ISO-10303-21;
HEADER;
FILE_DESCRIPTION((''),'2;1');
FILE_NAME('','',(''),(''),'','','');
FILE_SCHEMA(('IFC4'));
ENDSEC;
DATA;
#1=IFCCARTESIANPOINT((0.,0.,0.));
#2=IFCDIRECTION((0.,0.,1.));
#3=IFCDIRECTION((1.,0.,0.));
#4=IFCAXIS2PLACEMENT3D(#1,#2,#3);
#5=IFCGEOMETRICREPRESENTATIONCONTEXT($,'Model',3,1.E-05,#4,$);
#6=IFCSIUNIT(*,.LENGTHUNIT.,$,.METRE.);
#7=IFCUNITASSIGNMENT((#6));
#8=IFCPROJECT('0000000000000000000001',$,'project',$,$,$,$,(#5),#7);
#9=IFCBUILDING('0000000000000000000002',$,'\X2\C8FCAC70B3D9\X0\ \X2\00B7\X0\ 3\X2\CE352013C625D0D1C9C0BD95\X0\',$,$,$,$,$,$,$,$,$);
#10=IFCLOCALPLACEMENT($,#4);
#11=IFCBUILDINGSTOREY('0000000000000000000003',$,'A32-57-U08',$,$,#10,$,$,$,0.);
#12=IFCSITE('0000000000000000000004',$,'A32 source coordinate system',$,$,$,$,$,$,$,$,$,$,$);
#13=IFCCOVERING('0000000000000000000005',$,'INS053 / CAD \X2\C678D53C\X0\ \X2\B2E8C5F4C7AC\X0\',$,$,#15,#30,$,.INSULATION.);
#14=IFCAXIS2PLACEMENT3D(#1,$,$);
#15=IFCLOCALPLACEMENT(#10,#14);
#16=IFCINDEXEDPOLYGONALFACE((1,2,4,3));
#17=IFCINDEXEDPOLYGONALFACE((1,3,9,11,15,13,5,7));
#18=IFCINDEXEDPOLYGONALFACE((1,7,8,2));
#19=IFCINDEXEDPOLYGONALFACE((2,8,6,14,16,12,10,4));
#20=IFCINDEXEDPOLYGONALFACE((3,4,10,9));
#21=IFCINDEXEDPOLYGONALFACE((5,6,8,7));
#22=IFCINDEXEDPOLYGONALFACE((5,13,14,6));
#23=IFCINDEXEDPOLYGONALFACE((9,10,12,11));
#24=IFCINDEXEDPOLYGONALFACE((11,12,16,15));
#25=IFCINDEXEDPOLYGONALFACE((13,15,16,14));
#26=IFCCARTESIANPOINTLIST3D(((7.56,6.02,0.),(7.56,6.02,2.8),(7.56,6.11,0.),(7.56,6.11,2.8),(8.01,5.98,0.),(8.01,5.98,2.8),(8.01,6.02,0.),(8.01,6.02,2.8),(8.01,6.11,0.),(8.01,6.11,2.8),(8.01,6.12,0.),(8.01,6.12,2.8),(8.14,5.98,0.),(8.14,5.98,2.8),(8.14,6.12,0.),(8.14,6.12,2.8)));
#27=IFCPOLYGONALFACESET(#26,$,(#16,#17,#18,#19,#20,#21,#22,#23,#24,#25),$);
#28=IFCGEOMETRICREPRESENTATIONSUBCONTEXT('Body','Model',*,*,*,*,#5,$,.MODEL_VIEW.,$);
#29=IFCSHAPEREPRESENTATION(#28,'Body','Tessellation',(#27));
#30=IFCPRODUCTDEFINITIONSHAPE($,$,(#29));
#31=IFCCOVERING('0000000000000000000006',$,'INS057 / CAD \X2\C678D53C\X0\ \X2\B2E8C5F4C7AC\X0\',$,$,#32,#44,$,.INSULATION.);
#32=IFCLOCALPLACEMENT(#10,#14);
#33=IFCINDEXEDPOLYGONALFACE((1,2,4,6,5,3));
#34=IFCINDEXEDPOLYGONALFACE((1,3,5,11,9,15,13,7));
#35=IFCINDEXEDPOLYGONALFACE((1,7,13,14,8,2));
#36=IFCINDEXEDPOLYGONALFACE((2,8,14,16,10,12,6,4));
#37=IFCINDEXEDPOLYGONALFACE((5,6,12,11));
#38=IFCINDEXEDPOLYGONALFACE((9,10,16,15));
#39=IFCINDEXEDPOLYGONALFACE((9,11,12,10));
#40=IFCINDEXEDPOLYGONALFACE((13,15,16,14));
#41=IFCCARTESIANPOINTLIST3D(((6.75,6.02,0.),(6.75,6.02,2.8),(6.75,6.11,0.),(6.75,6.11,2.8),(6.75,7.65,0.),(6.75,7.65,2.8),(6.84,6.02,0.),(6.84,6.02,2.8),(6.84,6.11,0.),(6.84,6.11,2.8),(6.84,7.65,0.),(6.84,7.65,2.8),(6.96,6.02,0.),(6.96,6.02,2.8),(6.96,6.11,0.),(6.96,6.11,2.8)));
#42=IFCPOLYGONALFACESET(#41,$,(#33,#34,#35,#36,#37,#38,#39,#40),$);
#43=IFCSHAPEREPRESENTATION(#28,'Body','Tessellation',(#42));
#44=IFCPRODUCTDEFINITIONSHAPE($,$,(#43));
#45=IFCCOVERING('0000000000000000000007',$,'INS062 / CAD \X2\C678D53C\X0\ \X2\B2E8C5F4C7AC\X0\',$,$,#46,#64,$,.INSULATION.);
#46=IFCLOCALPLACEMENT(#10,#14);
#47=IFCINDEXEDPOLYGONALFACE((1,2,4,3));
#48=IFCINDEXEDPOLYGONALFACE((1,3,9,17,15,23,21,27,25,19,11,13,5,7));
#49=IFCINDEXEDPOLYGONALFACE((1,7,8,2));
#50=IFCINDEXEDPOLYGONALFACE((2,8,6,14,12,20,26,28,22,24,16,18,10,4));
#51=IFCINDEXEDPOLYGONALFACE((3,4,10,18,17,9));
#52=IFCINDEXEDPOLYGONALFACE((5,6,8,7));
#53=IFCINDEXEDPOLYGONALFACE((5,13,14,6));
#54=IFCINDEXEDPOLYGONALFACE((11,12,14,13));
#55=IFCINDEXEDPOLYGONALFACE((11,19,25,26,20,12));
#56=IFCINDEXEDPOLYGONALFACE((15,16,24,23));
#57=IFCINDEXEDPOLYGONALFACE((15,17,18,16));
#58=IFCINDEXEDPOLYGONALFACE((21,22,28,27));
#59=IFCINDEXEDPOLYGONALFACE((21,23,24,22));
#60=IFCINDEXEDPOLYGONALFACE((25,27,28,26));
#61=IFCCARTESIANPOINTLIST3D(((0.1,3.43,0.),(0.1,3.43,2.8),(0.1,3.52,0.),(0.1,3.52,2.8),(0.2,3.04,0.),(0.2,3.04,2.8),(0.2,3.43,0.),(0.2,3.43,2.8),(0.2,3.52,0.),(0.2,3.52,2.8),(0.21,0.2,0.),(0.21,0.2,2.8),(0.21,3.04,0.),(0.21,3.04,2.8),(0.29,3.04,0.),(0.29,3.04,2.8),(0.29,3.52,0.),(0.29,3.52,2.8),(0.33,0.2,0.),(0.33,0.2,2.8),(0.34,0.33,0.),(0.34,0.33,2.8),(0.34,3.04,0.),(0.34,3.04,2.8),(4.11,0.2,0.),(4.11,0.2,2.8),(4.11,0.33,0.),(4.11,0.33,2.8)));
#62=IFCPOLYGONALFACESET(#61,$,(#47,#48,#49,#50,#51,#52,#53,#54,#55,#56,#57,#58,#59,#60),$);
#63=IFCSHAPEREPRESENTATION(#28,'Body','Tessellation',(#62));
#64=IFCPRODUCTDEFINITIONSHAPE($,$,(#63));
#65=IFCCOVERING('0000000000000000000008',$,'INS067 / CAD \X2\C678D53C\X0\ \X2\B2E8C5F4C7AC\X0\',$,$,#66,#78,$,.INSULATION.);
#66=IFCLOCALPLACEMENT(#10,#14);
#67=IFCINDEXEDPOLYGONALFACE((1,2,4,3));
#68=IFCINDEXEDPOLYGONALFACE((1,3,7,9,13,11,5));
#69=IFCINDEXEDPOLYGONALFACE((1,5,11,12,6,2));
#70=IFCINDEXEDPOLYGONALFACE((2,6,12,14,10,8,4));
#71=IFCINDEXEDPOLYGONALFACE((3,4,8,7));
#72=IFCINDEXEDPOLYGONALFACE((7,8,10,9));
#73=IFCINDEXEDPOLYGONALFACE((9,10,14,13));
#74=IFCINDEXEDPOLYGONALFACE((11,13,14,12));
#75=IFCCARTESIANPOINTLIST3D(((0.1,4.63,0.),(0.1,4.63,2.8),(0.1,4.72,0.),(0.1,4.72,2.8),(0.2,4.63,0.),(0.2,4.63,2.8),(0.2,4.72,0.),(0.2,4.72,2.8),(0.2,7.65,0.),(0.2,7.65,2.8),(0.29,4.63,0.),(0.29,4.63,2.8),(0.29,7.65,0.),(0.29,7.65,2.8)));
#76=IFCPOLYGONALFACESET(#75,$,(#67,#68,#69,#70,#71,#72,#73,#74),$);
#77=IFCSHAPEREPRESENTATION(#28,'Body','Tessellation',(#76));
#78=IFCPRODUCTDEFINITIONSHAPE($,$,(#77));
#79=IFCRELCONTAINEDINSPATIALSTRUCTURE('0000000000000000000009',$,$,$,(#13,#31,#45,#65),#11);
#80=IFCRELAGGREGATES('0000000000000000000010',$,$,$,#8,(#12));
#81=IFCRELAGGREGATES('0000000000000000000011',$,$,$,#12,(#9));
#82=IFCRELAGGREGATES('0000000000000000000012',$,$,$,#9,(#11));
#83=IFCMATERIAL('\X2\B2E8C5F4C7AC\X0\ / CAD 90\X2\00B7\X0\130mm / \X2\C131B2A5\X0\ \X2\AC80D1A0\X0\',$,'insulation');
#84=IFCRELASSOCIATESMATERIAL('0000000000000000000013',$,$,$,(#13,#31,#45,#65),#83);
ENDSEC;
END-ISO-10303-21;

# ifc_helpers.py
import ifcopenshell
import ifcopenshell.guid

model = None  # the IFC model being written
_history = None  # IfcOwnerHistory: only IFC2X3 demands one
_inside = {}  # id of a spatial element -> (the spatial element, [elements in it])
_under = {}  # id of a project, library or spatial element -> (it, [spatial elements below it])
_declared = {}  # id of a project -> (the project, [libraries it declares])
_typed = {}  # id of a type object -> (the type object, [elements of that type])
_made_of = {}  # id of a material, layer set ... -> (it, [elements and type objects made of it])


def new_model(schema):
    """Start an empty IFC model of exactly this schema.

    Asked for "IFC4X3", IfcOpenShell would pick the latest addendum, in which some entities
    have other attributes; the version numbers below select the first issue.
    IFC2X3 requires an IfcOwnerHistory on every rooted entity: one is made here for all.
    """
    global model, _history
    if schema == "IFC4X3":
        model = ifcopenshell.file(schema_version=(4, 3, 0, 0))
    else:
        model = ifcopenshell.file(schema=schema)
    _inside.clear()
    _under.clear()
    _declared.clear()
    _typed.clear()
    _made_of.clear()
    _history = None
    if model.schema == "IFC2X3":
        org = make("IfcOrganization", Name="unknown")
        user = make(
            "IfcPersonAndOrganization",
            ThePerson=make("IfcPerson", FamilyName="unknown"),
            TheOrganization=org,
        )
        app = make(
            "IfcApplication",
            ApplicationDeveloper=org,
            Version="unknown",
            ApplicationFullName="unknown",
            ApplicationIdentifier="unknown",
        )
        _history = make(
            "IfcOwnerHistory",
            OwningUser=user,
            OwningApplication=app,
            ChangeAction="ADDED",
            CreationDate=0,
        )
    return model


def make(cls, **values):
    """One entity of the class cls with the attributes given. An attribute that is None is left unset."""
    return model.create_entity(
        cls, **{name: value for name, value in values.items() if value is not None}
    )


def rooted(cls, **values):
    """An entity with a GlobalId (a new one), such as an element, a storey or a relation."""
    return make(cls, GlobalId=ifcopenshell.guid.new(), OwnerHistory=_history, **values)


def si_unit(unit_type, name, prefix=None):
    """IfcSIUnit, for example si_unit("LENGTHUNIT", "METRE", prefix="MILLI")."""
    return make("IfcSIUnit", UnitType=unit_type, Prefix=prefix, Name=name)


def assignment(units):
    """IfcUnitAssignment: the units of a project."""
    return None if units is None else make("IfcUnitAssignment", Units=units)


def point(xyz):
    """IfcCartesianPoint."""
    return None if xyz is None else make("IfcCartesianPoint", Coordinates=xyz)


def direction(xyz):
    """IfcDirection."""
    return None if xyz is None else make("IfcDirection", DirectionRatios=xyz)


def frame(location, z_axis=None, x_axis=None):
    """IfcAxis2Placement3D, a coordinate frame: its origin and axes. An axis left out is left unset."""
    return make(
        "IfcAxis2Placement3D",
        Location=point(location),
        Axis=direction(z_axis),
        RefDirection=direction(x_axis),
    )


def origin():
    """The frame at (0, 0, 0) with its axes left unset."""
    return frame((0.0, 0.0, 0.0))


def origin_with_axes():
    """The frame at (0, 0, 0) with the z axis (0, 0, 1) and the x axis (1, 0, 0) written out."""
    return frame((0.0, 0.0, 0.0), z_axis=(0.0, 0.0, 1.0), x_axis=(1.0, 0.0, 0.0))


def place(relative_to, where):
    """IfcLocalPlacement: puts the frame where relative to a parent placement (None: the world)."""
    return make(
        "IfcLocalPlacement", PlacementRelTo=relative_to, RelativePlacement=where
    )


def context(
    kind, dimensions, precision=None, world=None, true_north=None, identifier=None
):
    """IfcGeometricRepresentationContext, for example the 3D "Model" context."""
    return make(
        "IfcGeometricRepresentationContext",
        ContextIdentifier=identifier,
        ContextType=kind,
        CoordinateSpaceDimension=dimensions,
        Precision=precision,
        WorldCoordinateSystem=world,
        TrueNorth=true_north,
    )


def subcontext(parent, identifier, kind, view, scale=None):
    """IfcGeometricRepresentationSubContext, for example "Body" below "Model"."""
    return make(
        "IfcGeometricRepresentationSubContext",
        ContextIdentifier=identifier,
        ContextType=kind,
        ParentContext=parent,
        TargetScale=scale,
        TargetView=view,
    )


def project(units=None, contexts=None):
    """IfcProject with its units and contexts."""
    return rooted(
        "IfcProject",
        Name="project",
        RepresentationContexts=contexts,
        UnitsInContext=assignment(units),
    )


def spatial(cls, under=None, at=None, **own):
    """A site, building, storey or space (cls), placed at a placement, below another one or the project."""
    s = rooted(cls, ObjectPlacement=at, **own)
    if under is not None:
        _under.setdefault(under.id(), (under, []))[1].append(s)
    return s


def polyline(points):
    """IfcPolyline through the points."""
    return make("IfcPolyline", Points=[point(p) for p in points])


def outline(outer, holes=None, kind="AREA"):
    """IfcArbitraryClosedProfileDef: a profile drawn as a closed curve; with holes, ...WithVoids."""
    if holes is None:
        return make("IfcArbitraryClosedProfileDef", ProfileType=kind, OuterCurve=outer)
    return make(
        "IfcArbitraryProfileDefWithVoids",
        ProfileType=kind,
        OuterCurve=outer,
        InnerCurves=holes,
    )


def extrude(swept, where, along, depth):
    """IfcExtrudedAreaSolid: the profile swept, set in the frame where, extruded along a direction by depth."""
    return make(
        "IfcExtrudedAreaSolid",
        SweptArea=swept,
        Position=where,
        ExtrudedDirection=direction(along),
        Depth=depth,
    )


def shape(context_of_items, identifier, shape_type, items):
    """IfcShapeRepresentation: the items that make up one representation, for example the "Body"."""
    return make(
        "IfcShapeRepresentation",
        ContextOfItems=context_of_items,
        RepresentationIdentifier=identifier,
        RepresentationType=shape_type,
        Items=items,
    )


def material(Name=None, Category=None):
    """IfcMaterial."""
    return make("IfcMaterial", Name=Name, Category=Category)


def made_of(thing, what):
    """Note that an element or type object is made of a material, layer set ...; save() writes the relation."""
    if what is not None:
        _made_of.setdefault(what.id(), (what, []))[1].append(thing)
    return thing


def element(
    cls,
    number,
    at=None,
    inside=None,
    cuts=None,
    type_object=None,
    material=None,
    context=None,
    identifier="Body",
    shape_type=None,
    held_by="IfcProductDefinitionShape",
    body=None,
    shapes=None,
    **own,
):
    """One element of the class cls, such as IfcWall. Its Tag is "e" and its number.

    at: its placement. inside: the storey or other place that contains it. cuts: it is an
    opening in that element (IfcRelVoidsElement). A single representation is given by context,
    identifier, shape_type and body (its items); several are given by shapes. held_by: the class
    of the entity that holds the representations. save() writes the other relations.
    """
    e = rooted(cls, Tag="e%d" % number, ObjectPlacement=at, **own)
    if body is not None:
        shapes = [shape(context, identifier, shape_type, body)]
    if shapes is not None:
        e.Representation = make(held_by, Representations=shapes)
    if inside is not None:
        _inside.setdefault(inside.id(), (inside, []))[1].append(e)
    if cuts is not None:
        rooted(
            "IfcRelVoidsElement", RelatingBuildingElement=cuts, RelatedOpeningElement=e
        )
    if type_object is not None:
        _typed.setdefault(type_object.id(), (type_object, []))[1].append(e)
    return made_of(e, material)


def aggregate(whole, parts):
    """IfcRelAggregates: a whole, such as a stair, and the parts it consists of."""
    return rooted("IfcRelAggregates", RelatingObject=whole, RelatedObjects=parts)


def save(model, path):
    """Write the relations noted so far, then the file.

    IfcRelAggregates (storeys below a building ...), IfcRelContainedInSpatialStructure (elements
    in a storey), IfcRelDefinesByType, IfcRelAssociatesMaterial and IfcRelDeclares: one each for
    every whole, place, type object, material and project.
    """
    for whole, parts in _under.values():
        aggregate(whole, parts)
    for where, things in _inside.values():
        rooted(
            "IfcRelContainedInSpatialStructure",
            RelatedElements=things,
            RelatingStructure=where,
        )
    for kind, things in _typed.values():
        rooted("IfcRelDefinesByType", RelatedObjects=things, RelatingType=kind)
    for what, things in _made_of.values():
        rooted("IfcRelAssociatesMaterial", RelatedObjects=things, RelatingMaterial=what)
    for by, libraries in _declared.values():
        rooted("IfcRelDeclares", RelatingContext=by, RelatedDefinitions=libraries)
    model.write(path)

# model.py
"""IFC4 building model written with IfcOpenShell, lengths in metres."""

from ifc_helpers import new_model, si_unit, origin, origin_with_axes, place, context, subcontext, project, spatial, polyline, outline, extrude, material, element, save


model = new_model("IFC4")

# Units and contexts
model_context = context("Model", 3, precision=1e-05, world=origin_with_axes())
body_context = subcontext(model_context, "Body", "Model", "MODEL_VIEW")
ifc_project = project(units=[si_unit("LENGTHUNIT", "METRE")], contexts=[model_context])

# Site, building, storey
storey_placement = place(None, origin_with_axes())
site = spatial("IfcSite", under=ifc_project, Name="A32 source coordinate system")
building = spatial("IfcBuilding", under=site, Name="주거동 · 3층–옥탑지붕")
storey = spatial("IfcBuildingStorey", under=building, at=storey_placement, Name="A32-57-U08", Elevation=0.0)

# Coverings
ifc_material = material(Name="단열재 / CAD 90·130mm / 성능 검토", Category="insulation")
covering_1_placement = place(storey_placement, origin_with_axes())
element("IfcCovering", 1, at=covering_1_placement, inside=storey, material=ifc_material, Name="INS053 / CAD 외피 단열재", PredefinedType="INSULATION", context=body_context, shape_type="SweptSolid", body=[
    extrude(outline(polyline([(8.01, 6.12), (8.14, 6.12), (8.14, 5.98), (8.01, 5.98), (8.01, 6.02), (7.56, 6.02), (7.56, 6.11), (8.01, 6.11), (8.01, 6.12)])), origin(), (0.0, 0.0, 1.0), 2.8),
])
covering_2_placement = place(storey_placement, origin_with_axes())
element("IfcCovering", 2, at=covering_2_placement, inside=storey, material=ifc_material, Name="INS057 / CAD 외피 단열재", PredefinedType="INSULATION", context=body_context, shape_type="SweptSolid", body=[
    extrude(outline(polyline([(6.84, 6.11), (6.96, 6.11), (6.96, 6.02), (6.84, 6.02), (6.75, 6.02), (6.75, 6.11), (6.75, 7.65), (6.84, 7.65), (6.84, 6.11)])), origin(), (0.0, 0.0, 1.0), 2.8),
])
covering_3_placement = place(storey_placement, origin_with_axes())
element("IfcCovering", 3, at=covering_3_placement, inside=storey, material=ifc_material, Name="INS062 / CAD 외피 단열재", PredefinedType="INSULATION", context=body_context, shape_type="SweptSolid", body=[
    extrude(outline(polyline([(4.11, 0.2), (0.33, 0.2), (0.21, 0.2), (0.21, 3.04), (0.2, 3.04), (0.2, 3.43), (0.1, 3.43), (0.1, 3.52), (0.2, 3.52), (0.29, 3.52), (0.29, 3.04), (0.34, 3.04), (0.34, 0.33), (4.11, 0.33), (4.11, 0.2)])), origin(), (0.0, 0.0, 1.0), 2.8),
])
covering_4_placement = place(storey_placement, origin_with_axes())
element("IfcCovering", 4, at=covering_4_placement, inside=storey, material=ifc_material, Name="INS067 / CAD 외피 단열재", PredefinedType="INSULATION", context=body_context, shape_type="SweptSolid", body=[
    extrude(outline(polyline([(0.1, 4.72), (0.2, 4.72), (0.2, 7.65), (0.29, 7.65), (0.29, 4.63), (0.2, 4.63), (0.1, 4.63), (0.1, 4.72)])), origin(), (0.0, 0.0, 1.0), 2.8),
])

save(model, "model.ifc")
